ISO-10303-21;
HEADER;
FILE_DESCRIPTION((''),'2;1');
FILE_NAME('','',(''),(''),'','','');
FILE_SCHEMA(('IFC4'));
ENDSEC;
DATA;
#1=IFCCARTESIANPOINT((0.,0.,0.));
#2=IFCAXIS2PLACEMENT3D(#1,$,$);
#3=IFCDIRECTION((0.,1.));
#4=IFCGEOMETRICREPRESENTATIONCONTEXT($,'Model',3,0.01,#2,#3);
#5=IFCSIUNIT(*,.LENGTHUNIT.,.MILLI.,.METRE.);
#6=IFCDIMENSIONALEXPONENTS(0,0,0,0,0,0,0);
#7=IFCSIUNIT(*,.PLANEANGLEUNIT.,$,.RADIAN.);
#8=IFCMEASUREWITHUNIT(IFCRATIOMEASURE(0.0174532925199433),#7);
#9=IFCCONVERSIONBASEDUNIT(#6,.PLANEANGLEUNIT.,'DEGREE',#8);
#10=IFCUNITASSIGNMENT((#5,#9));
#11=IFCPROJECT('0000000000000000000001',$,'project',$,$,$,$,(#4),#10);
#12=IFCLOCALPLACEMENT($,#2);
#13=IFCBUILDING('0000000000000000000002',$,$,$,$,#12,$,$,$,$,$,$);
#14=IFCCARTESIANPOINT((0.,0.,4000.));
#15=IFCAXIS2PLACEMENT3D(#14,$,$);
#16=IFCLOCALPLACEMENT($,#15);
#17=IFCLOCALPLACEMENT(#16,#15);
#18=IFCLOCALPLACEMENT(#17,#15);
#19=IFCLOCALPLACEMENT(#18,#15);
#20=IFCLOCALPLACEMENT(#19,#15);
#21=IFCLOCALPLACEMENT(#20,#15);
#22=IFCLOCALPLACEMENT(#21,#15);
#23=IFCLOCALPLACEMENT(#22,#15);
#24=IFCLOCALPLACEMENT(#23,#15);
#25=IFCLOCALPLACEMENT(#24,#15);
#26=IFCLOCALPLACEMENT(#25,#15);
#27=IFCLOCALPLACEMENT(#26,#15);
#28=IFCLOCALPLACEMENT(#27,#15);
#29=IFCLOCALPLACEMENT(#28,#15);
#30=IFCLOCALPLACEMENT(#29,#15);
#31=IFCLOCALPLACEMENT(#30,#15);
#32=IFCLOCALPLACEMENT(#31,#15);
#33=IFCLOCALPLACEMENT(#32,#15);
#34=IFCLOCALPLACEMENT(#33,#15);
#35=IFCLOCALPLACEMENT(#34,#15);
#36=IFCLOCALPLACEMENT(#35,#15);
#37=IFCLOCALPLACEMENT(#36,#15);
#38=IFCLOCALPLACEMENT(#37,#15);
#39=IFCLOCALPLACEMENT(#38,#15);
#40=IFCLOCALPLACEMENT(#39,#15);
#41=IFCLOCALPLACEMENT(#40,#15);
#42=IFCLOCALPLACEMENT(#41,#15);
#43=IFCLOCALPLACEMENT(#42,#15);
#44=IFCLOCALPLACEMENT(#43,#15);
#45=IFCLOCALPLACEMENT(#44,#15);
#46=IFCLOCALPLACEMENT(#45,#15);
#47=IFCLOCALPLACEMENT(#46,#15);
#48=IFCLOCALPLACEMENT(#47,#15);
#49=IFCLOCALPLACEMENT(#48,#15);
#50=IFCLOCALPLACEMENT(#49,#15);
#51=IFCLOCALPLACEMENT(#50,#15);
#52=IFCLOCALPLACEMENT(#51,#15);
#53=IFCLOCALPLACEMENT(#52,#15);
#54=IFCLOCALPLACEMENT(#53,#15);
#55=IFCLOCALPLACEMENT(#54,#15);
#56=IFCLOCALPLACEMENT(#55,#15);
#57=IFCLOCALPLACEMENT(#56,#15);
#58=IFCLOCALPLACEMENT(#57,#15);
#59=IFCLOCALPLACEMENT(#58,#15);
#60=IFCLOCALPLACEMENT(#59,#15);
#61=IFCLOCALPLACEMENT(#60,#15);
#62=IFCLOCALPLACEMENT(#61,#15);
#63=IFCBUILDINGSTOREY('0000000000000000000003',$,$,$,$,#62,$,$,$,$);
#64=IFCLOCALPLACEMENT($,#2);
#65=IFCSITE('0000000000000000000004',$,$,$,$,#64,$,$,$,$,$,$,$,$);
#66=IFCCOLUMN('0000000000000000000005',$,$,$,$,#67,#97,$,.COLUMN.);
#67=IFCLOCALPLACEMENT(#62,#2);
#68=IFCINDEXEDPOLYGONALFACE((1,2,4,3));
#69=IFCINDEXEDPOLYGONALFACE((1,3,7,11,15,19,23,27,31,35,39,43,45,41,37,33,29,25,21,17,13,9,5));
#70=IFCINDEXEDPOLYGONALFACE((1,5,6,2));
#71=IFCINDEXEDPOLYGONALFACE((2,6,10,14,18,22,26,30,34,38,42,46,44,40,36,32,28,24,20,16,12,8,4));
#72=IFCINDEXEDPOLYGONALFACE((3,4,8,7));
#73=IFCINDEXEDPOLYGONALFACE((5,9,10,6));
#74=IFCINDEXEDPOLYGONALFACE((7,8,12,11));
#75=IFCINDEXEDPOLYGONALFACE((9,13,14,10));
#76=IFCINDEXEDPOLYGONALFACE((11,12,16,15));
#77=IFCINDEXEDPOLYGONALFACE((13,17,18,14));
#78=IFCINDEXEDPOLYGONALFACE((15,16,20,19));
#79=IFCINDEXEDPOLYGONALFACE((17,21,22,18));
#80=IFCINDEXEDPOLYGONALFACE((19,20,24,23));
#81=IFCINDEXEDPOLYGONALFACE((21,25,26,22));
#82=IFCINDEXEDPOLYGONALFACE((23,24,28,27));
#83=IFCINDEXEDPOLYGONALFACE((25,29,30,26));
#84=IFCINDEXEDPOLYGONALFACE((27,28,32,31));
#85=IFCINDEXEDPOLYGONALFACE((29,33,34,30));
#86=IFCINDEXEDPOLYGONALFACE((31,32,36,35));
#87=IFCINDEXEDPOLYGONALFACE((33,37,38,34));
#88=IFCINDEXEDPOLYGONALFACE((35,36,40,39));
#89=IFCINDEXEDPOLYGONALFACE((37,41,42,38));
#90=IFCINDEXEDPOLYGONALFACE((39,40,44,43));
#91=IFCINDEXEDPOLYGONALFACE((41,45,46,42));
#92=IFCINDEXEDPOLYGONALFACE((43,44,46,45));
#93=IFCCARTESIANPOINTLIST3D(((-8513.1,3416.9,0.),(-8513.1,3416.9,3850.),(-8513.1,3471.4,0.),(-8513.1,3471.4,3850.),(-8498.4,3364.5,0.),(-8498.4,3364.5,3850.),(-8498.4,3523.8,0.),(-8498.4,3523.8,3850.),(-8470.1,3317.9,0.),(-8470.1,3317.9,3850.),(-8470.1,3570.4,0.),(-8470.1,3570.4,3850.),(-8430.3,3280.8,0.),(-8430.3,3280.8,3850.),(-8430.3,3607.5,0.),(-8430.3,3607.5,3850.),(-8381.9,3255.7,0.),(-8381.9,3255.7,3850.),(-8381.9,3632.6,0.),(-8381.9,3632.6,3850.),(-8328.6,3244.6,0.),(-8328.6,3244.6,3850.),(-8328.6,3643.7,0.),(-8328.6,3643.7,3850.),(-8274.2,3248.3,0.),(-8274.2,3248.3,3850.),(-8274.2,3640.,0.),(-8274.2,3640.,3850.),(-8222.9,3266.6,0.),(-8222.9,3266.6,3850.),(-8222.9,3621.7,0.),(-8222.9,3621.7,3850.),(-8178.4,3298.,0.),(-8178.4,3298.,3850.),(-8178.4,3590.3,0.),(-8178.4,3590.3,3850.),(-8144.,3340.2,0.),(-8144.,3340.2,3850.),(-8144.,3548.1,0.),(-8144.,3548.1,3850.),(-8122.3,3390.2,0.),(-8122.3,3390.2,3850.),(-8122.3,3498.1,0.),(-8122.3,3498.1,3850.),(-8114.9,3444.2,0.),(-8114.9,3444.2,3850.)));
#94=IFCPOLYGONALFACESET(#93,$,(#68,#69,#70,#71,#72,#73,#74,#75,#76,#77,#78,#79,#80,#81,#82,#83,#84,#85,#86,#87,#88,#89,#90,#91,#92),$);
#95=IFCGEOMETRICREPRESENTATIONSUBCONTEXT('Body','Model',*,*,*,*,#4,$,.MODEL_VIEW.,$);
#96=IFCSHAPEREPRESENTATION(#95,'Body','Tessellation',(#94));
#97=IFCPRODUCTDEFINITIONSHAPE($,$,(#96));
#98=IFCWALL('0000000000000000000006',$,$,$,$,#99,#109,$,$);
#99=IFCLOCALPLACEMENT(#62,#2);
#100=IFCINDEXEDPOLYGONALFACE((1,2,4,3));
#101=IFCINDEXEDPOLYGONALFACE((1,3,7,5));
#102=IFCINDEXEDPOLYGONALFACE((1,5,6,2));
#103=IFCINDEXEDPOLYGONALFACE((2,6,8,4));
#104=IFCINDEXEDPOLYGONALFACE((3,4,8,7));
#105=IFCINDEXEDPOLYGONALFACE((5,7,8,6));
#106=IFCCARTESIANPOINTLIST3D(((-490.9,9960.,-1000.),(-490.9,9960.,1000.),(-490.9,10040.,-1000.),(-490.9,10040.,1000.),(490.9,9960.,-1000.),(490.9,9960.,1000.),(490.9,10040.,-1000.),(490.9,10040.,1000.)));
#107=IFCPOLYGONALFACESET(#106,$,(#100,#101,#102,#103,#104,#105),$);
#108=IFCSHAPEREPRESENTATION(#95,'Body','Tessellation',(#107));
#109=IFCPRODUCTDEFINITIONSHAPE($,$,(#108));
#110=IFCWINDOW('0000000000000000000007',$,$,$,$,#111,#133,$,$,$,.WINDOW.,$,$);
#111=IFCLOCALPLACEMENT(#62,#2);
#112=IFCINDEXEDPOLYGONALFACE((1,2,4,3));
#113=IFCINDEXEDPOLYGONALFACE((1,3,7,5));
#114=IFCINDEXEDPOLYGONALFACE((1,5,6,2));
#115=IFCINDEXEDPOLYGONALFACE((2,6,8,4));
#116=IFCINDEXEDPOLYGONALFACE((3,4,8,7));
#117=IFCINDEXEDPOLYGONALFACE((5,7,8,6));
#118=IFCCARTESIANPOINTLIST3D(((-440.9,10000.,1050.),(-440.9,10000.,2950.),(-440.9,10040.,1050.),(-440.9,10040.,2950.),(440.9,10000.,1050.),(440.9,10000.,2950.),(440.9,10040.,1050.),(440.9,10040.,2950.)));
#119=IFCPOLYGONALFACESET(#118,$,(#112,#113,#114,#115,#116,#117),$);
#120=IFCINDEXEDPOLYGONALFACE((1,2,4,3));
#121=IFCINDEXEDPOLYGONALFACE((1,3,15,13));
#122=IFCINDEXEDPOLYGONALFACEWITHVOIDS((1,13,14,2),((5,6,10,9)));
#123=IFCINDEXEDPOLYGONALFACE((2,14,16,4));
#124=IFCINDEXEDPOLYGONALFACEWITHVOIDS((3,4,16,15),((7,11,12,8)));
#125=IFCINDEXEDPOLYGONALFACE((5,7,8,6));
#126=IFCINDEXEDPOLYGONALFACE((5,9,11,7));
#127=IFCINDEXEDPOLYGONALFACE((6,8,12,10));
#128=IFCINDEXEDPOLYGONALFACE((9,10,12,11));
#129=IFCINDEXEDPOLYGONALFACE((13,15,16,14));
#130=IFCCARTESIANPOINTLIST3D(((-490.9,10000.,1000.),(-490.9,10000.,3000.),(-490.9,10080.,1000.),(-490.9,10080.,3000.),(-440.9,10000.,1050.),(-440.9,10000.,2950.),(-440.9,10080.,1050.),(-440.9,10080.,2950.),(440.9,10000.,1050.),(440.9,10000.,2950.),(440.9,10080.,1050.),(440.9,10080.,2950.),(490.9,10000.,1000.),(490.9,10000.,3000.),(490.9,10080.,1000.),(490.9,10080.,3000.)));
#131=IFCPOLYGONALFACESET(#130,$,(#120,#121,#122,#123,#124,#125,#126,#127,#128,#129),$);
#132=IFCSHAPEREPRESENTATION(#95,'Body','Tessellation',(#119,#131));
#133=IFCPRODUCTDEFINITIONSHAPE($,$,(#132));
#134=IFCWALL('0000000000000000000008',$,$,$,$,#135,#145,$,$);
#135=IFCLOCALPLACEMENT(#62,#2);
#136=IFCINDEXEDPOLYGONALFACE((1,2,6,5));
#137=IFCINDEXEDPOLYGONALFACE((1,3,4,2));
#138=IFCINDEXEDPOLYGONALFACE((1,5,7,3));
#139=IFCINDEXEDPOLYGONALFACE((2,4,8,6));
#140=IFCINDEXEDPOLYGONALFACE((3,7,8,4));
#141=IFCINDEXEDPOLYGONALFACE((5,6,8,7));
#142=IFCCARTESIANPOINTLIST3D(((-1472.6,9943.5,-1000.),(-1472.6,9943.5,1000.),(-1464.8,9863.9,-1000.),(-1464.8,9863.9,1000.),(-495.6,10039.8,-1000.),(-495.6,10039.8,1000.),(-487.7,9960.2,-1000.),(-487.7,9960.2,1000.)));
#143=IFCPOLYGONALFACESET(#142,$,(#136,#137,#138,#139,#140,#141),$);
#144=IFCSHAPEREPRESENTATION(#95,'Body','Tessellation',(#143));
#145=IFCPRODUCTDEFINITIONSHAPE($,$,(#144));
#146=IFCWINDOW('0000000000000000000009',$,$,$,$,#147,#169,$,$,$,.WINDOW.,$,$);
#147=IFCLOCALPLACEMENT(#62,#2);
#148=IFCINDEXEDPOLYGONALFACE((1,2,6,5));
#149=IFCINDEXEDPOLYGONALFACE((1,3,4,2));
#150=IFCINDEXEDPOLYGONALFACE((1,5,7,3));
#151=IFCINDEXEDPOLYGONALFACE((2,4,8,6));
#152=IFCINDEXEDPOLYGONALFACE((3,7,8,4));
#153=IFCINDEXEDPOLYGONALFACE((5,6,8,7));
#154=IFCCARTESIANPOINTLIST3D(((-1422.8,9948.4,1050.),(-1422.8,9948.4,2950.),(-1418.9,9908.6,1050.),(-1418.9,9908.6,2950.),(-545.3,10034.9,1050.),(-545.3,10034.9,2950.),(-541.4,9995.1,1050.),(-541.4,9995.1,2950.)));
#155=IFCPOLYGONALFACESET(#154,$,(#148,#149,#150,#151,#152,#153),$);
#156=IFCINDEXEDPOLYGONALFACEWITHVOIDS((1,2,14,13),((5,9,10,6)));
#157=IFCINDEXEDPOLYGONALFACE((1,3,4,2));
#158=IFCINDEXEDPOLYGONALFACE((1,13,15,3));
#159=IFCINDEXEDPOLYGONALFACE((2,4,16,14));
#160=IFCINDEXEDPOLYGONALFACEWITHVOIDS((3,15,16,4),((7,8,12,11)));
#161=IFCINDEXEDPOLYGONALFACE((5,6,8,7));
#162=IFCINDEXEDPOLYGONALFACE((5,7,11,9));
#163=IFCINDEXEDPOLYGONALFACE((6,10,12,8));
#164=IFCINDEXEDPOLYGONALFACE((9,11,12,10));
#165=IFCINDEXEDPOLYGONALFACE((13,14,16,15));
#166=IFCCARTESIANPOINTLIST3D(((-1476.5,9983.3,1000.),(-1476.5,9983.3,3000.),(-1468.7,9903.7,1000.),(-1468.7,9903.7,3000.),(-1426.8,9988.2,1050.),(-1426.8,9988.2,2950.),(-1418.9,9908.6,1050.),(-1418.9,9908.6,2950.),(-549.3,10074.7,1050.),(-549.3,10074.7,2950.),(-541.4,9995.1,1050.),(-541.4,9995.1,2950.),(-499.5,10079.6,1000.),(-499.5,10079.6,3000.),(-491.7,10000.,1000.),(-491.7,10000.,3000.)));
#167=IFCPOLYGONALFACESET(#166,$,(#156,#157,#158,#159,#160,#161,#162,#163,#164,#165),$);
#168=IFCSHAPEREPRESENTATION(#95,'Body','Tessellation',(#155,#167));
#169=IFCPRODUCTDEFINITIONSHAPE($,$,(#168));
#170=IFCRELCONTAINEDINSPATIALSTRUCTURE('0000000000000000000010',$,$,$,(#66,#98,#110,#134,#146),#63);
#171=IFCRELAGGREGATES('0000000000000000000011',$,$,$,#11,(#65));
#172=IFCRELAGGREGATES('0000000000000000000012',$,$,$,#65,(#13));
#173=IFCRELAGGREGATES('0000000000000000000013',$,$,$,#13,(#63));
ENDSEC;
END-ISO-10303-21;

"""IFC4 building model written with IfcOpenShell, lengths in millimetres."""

from ifc_helpers import new_model, entity, si_unit, converted_unit, direction, frame, origin, origin_2d, place, context, subcontext, project, spatial, rectangle, circle, extrude, element, save


model = new_model("IFC4")

# Units and contexts
model_context = context("Model", 3, precision=0.01, world=origin(), true_north=direction((0.0, 1.0)))
body_context = subcontext(model_context, "Body", "Model", "MODEL_VIEW")
ifc_project = project(units=[si_unit("LENGTHUNIT", "METRE", prefix="MILLI"), converted_unit("PLANEANGLEUNIT", "DEGREE", entity("IfcRatioMeasure", 0.0174532925199433), si_unit("PLANEANGLEUNIT", "RADIAN"), dimensions=[0, 0, 0, 0, 0, 0, 0])], contexts=[model_context])

# Site, building, storey
site_placement = place(None, origin())
site = spatial("IfcSite", under=ifc_project, at=site_placement)
building_placement = place(None, origin())
building = spatial("IfcBuilding", under=site, at=building_placement)
placement_1 = place(None, frame((0.0, 0.0, 4000.0)))
placement_2 = place(placement_1, frame((0.0, 0.0, 4000.0)))
placement_3 = place(placement_2, frame((0.0, 0.0, 4000.0)))
placement_4 = place(placement_3, frame((0.0, 0.0, 4000.0)))
placement_5 = place(placement_4, frame((0.0, 0.0, 4000.0)))
placement_6 = place(placement_5, frame((0.0, 0.0, 4000.0)))
placement_7 = place(placement_6, frame((0.0, 0.0, 4000.0)))
placement_8 = place(placement_7, frame((0.0, 0.0, 4000.0)))
placement_9 = place(placement_8, frame((0.0, 0.0, 4000.0)))
placement_10 = place(placement_9, frame((0.0, 0.0, 4000.0)))
placement_11 = place(placement_10, frame((0.0, 0.0, 4000.0)))
placement_12 = place(placement_11, frame((0.0, 0.0, 4000.0)))
placement_13 = place(placement_12, frame((0.0, 0.0, 4000.0)))
placement_14 = place(placement_13, frame((0.0, 0.0, 4000.0)))
placement_15 = place(placement_14, frame((0.0, 0.0, 4000.0)))
placement_16 = place(placement_15, frame((0.0, 0.0, 4000.0)))
placement_17 = place(placement_16, frame((0.0, 0.0, 4000.0)))
placement_18 = place(placement_17, frame((0.0, 0.0, 4000.0)))
placement_19 = place(placement_18, frame((0.0, 0.0, 4000.0)))
placement_20 = place(placement_19, frame((0.0, 0.0, 4000.0)))
placement_21 = place(placement_20, frame((0.0, 0.0, 4000.0)))
placement_22 = place(placement_21, frame((0.0, 0.0, 4000.0)))
placement_23 = place(placement_22, frame((0.0, 0.0, 4000.0)))
placement_24 = place(placement_23, frame((0.0, 0.0, 4000.0)))
placement_25 = place(placement_24, frame((0.0, 0.0, 4000.0)))
placement_26 = place(placement_25, frame((0.0, 0.0, 4000.0)))
placement_27 = place(placement_26, frame((0.0, 0.0, 4000.0)))
placement_28 = place(placement_27, frame((0.0, 0.0, 4000.0)))
placement_29 = place(placement_28, frame((0.0, 0.0, 4000.0)))
placement_30 = place(placement_29, frame((0.0, 0.0, 4000.0)))
placement_31 = place(placement_30, frame((0.0, 0.0, 4000.0)))
placement_32 = place(placement_31, frame((0.0, 0.0, 4000.0)))
placement_33 = place(placement_32, frame((0.0, 0.0, 4000.0)))
placement_34 = place(placement_33, frame((0.0, 0.0, 4000.0)))
placement_35 = place(placement_34, frame((0.0, 0.0, 4000.0)))
placement_36 = place(placement_35, frame((0.0, 0.0, 4000.0)))
placement_37 = place(placement_36, frame((0.0, 0.0, 4000.0)))
placement_38 = place(placement_37, frame((0.0, 0.0, 4000.0)))
placement_39 = place(placement_38, frame((0.0, 0.0, 4000.0)))
placement_40 = place(placement_39, frame((0.0, 0.0, 4000.0)))
placement_41 = place(placement_40, frame((0.0, 0.0, 4000.0)))
placement_42 = place(placement_41, frame((0.0, 0.0, 4000.0)))
placement_43 = place(placement_42, frame((0.0, 0.0, 4000.0)))
placement_44 = place(placement_43, frame((0.0, 0.0, 4000.0)))
placement_45 = place(placement_44, frame((0.0, 0.0, 4000.0)))
placement_46 = place(placement_45, frame((0.0, 0.0, 4000.0)))
storey_placement = place(placement_46, frame((0.0, 0.0, 4000.0)))
storey = spatial("IfcBuildingStorey", under=building, at=storey_placement)

# Column
for number, where in (
    (1, (-8314.9, 3444.2, 0.0)),
):
    element("IfcColumn", number, at=place(storey_placement, frame(where)), inside=storey, PredefinedType="COLUMN", context=body_context, shape_type="SweptSolid", body=[
        extrude(circle(Radius=200.0, at=origin_2d()), origin(), (0.0, 0.0, 1.0), 3850.0),
    ])

# Wall
wall_1_placement = place(storey_placement, frame((0.0, 10000.0, -1000.0), z_axis=(0.0, 0.0, 1.0), x_axis=(-10000.0, -0.000437, 0.0)))
element("IfcWall", 2, at=wall_1_placement, inside=storey, context=body_context, shape_type="SweptSolid", body=[
    extrude(rectangle(XDim=981.7, YDim=80.0, at=origin_2d()), origin(), (0.0, 0.0, 1.0), 2000.0),
])

# Window
cartesian_point_1 = entity("IfcCartesianPoint", [-440.9, -950.0])
shared_polyline = entity("IfcPolyline", [cartesian_point_1, entity("IfcCartesianPoint", [-440.9, 950.0]), entity("IfcCartesianPoint", [-440.9, 950.0]), entity("IfcCartesianPoint", [440.9, 950.0]), entity("IfcCartesianPoint", [440.9, 950.0]), entity("IfcCartesianPoint", [440.9, -950.0]), entity("IfcCartesianPoint", [440.9, -950.0]), entity("IfcCartesianPoint", [-440.9, -950.0]), cartesian_point_1])
window_1_placement = place(storey_placement, frame((0.0, 10000.0, 2000.0), z_axis=(0.0, 0.0, 1.0), x_axis=(-10000.0, -0.000437, 0.0)))
cartesian_point_2 = entity("IfcCartesianPoint", [-490.9, -1000.0])
element("IfcWindow", 3, at=window_1_placement, inside=storey, PredefinedType="WINDOW", context=body_context, shape_type="SweptSolid", body=[
    entity("IfcExtrudedAreaSolid", entity("IfcArbitraryClosedProfileDef", "AREA", None, shared_polyline), entity("IfcAxis2Placement3D", entity("IfcCartesianPoint", [0.0, 0.0, 0.0]), entity("IfcDirection", [0.0, -1.0, 0.0]), entity("IfcDirection", [1.0, 0.0, 0.0])), entity("IfcDirection", [0.0, 0.0, 1.0]), 40.0),
    entity("IfcExtrudedAreaSolid", entity("IfcArbitraryProfileDefWithVoids", "AREA", None, entity("IfcPolyline", [cartesian_point_2, entity("IfcCartesianPoint", [-490.9, 1000.0]), entity("IfcCartesianPoint", [-490.9, 1000.0]), entity("IfcCartesianPoint", [490.9, 1000.0]), entity("IfcCartesianPoint", [490.9, 1000.0]), entity("IfcCartesianPoint", [490.9, -1000.0]), entity("IfcCartesianPoint", [490.9, -1000.0]), entity("IfcCartesianPoint", [-490.9, -1000.0]), cartesian_point_2]), [shared_polyline]), entity("IfcAxis2Placement3D", entity("IfcCartesianPoint", [0.0, 0.0, 0.0]), entity("IfcDirection", [0.0, -1.0, 0.0]), entity("IfcDirection", [1.0, 0.0, 0.0])), entity("IfcDirection", [0.0, 0.0, 1.0]), 80.0),
])

# Wall
wall_2_placement = place(storey_placement, frame((-980.2, 9951.8, -1000.0), z_axis=(0.0, 0.0, 1.0), x_axis=(-9951.847302, -980.17105, 0.0)))
element("IfcWall", 4, at=wall_2_placement, inside=storey, context=body_context, shape_type="SweptSolid", body=[
    extrude(rectangle(XDim=981.7, YDim=80.0, at=origin_2d()), origin(), (0.0, 0.0, 1.0), 2000.0),
])

# Window
window_2_placement = place(storey_placement, frame((-980.2, 9951.8, 2000.0), z_axis=(0.0, 0.0, 1.0), x_axis=(-9951.847302, -980.17105, 0.0)))
cartesian_point_3 = entity("IfcCartesianPoint", [-490.9, -1000.0])
element("IfcWindow", 5, at=window_2_placement, inside=storey, PredefinedType="WINDOW", context=body_context, shape_type="SweptSolid", body=[
    entity("IfcExtrudedAreaSolid", entity("IfcArbitraryClosedProfileDef", "AREA", None, shared_polyline), entity("IfcAxis2Placement3D", entity("IfcCartesianPoint", [0.0, 0.0, 0.0]), entity("IfcDirection", [0.0, -1.0, 0.0]), entity("IfcDirection", [1.0, 0.0, 0.0])), entity("IfcDirection", [0.0, 0.0, 1.0]), 40.0),
    entity("IfcExtrudedAreaSolid", entity("IfcArbitraryProfileDefWithVoids", "AREA", None, entity("IfcPolyline", [cartesian_point_3, entity("IfcCartesianPoint", [-490.9, 1000.0]), entity("IfcCartesianPoint", [-490.9, 1000.0]), entity("IfcCartesianPoint", [490.9, 1000.0]), entity("IfcCartesianPoint", [490.9, 1000.0]), entity("IfcCartesianPoint", [490.9, -1000.0]), entity("IfcCartesianPoint", [490.9, -1000.0]), entity("IfcCartesianPoint", [-490.9, -1000.0]), cartesian_point_3]), [shared_polyline]), entity("IfcAxis2Placement3D", entity("IfcCartesianPoint", [0.0, 0.0, 0.0]), entity("IfcDirection", [0.0, -1.0, 0.0]), entity("IfcDirection", [1.0, 0.0, 0.0])), entity("IfcDirection", [0.0, 0.0, 1.0]), 80.0),
])

save(model, "model.ifc")
